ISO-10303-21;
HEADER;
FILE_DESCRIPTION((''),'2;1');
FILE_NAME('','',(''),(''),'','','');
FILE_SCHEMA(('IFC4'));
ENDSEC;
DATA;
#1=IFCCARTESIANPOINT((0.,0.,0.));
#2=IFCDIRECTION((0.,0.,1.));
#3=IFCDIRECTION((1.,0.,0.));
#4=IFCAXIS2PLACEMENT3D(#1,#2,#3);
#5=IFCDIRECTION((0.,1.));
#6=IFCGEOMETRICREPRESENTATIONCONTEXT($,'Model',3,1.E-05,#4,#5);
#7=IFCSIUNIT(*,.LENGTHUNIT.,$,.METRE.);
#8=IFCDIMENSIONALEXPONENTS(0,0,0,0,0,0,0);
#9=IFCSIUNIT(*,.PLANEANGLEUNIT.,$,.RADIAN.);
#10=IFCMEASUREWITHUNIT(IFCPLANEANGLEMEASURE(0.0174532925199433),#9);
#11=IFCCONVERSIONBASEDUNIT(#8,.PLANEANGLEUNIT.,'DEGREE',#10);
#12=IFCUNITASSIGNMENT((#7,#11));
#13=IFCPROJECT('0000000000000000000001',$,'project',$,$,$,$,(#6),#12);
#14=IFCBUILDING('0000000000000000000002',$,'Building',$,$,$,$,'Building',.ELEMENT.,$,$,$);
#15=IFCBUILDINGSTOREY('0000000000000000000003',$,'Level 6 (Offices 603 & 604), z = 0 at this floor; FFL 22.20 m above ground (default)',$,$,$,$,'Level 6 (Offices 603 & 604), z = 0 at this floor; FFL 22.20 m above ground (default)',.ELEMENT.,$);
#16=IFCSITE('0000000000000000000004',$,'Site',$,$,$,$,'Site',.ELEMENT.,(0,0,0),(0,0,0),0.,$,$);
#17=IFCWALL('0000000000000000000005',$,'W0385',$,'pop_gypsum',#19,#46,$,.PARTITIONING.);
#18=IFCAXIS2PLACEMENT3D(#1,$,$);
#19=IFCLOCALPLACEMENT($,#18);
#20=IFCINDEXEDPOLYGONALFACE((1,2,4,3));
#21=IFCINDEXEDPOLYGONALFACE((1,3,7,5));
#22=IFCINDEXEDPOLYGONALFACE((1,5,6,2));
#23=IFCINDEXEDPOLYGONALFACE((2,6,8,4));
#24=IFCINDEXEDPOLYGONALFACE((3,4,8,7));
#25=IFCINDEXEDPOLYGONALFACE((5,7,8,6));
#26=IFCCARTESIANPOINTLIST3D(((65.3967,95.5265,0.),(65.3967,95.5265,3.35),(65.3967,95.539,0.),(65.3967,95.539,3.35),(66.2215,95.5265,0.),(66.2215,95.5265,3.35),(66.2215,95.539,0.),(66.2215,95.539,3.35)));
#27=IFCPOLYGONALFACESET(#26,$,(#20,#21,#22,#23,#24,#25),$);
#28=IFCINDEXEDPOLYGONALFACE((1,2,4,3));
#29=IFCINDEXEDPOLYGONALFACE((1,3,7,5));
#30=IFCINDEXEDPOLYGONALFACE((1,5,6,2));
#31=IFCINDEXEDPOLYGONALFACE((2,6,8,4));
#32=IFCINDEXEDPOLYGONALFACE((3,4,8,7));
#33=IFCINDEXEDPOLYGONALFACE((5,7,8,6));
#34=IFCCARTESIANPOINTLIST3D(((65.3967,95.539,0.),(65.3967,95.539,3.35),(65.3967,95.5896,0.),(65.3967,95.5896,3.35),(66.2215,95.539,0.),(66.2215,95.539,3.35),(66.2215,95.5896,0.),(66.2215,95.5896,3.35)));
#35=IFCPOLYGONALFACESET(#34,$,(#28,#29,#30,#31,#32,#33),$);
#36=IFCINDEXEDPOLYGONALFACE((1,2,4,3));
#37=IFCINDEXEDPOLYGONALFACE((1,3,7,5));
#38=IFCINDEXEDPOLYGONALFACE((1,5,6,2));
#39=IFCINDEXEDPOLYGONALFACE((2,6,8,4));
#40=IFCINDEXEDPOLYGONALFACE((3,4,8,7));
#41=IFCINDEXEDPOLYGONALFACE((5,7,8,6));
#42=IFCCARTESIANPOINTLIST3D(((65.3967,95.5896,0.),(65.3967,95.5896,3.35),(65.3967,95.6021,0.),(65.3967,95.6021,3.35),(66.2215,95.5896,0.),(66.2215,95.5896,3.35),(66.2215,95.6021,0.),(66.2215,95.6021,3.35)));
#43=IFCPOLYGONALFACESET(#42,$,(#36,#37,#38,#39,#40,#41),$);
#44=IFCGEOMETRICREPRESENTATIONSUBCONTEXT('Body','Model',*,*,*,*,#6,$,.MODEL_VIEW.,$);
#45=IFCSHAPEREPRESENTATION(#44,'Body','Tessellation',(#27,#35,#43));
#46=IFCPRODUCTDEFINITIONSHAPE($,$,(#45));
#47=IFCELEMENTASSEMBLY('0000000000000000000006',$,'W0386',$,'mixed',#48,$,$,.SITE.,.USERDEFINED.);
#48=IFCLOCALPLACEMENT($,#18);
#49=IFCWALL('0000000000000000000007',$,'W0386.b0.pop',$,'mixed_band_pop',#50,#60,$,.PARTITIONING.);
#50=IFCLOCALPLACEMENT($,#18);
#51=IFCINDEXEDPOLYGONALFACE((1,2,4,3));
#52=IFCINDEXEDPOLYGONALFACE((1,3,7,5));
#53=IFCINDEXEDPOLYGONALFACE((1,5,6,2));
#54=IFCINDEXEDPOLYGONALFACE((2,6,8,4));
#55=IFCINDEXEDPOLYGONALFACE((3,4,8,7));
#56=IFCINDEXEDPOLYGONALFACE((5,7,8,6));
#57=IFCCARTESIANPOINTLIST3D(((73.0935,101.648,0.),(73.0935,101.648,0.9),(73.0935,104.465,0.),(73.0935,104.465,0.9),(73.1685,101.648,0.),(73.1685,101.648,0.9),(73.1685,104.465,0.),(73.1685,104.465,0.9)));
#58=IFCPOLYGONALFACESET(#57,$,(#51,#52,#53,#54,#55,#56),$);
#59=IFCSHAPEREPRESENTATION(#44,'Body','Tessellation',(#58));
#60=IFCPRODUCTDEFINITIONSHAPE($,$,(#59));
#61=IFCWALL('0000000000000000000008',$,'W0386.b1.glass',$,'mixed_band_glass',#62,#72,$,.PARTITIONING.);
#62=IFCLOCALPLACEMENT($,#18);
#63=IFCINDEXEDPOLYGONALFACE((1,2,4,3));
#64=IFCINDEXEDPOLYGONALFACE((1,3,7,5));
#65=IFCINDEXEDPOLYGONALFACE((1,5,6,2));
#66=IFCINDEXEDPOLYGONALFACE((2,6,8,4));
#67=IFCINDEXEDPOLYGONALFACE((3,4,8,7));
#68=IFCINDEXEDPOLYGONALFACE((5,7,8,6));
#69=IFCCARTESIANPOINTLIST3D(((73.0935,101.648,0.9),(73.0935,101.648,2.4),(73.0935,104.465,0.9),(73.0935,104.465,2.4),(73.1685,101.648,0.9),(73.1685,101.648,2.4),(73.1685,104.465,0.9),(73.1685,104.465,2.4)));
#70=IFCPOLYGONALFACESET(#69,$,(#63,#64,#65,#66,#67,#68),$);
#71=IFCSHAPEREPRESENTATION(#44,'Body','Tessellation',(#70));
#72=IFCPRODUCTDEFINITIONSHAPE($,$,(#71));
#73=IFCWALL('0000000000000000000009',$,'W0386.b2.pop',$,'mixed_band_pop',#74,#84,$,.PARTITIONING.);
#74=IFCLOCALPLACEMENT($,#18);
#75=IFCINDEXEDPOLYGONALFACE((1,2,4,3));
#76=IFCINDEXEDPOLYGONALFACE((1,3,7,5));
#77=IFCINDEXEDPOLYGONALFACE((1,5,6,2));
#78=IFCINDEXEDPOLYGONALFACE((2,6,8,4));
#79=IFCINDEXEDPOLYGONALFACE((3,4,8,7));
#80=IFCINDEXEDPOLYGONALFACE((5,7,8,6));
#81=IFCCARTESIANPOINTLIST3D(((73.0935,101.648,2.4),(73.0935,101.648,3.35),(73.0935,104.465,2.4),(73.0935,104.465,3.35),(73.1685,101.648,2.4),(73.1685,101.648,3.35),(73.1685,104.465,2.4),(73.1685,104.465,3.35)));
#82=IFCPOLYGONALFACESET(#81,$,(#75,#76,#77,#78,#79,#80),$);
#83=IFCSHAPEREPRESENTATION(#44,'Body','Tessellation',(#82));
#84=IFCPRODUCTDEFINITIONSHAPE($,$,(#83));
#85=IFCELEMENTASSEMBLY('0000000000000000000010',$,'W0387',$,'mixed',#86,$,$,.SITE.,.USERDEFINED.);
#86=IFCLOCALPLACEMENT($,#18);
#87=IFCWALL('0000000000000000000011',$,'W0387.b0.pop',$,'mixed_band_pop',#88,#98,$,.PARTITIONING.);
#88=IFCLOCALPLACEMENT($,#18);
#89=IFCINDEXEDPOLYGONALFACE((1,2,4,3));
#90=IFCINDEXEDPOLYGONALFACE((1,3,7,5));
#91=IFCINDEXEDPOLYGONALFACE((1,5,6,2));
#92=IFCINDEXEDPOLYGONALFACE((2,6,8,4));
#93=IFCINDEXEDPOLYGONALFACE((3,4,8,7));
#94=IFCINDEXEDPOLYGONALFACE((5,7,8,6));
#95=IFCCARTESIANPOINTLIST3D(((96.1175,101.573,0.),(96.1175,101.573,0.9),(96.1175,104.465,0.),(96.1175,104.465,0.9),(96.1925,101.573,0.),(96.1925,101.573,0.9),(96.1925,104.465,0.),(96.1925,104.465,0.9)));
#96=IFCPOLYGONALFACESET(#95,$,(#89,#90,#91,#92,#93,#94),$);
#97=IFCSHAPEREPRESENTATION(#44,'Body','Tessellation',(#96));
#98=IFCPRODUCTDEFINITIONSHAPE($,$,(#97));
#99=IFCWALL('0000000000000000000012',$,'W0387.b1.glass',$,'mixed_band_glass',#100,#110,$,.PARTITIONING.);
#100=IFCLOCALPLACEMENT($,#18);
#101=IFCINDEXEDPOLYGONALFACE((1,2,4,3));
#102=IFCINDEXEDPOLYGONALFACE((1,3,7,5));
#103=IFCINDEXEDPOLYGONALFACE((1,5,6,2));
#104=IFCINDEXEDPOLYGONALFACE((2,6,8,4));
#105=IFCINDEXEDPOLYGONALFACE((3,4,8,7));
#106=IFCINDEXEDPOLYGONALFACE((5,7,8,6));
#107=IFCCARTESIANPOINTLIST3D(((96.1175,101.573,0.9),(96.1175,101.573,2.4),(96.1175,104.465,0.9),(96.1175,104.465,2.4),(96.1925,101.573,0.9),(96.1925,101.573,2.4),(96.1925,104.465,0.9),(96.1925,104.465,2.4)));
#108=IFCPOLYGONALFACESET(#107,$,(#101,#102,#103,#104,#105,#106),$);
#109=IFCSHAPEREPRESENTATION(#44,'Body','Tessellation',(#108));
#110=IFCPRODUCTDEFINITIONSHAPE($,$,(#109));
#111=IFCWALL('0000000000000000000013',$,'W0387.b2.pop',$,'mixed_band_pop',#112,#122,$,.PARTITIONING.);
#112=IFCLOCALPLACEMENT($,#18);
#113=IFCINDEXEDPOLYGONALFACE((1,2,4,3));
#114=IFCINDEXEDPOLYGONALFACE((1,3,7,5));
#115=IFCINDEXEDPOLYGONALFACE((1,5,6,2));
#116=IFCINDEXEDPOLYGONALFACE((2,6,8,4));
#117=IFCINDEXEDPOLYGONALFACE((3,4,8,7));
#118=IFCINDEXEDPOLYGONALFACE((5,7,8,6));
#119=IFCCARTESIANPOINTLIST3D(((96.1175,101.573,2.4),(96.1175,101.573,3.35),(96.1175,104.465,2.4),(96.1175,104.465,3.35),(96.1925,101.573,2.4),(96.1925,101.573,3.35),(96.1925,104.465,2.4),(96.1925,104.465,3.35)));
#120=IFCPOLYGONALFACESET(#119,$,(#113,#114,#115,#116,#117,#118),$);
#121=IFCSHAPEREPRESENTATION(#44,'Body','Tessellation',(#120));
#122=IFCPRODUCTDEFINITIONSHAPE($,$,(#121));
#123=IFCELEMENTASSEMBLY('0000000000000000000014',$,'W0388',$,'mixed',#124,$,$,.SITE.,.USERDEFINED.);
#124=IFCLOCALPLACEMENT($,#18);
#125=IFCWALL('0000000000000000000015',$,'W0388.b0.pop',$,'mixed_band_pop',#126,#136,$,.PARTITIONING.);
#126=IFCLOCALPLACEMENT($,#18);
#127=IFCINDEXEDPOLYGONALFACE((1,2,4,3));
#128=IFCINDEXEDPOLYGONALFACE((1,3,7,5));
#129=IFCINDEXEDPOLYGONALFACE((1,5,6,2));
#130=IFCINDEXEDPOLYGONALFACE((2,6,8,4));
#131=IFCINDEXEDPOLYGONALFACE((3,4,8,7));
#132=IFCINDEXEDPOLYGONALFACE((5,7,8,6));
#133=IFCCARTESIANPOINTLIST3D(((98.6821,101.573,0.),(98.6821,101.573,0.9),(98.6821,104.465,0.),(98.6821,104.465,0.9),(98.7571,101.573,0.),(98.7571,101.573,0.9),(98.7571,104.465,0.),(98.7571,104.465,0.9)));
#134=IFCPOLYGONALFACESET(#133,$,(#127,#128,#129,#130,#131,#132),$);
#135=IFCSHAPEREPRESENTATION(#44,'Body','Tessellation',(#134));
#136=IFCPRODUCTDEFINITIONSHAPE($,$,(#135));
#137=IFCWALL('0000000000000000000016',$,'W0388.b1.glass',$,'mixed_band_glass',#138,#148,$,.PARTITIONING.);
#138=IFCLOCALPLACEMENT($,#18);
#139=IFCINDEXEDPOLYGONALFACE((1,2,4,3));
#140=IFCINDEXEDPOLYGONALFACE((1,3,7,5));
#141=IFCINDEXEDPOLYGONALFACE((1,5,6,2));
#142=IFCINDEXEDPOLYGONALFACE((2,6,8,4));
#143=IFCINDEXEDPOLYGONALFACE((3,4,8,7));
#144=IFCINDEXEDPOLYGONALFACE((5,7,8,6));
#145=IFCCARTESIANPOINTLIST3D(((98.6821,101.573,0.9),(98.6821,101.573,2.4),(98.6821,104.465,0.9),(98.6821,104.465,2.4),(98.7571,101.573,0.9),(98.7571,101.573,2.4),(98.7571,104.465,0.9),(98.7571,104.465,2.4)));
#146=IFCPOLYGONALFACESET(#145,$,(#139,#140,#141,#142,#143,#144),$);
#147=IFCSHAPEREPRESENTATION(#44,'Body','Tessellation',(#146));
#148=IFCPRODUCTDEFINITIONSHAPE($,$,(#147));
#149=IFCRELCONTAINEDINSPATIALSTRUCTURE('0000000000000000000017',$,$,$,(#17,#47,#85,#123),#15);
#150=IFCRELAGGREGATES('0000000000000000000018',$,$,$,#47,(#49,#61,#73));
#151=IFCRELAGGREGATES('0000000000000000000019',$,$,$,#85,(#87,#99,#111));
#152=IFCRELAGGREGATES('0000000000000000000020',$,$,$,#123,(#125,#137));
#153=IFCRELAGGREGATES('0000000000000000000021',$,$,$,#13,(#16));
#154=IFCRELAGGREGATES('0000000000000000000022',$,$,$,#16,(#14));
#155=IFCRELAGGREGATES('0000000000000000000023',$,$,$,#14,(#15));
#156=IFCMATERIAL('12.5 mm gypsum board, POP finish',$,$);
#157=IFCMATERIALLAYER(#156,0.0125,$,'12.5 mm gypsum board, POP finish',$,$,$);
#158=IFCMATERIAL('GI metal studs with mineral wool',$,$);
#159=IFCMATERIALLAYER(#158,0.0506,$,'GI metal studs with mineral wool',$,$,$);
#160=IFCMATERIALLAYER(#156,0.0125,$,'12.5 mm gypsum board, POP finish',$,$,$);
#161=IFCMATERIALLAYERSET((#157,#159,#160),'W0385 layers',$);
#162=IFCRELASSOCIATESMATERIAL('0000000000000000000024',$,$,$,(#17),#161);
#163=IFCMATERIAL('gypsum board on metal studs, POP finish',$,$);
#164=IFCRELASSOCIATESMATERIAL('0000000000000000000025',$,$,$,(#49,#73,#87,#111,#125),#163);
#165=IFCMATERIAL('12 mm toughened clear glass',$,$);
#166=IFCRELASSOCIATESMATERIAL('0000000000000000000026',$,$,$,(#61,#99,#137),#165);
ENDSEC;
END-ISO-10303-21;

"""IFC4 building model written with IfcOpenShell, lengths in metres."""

from ifc_helpers import new_model, entity, si_unit, converted_unit, direction, frame, frame_2d, origin_with_axes, place, context, subcontext, project, spatial, rectangle, extrude, material, layer, layer_set, layer_usage, element, aggregate, save


model = new_model("IFC4")

# Units and contexts
model_context = context("Model", 3, precision=1e-05, world=origin_with_axes(), true_north=direction((0.0, 1.0)))
body_context = subcontext(model_context, "Body", "Model", "MODEL_VIEW")
ifc_project = project(units=[si_unit("LENGTHUNIT", "METRE"), converted_unit("PLANEANGLEUNIT", "DEGREE", entity("IfcPlaneAngleMeasure", 0.0174532925199433), si_unit("PLANEANGLEUNIT", "RADIAN"), dimensions=[0, 0, 0, 0, 0, 0, 0])], contexts=[model_context])

# Site, building, storey
site = spatial("IfcSite", under=ifc_project, Name="Site", LongName="Site", CompositionType="ELEMENT", RefLatitude=(0, 0, 0), RefLongitude=(0, 0, 0), RefElevation=0.0)
building = spatial("IfcBuilding", under=site, Name="Building", LongName="Building", CompositionType="ELEMENT")
storey = spatial("IfcBuildingStorey", under=building, Name="Level 6 (Offices 603 & 604), z = 0 at this floor; FFL 22.20 m above ground (default)", LongName="Level 6 (Offices 603 & 604), z = 0 at this floor; FFL 22.20 m above ground (default)", CompositionType="ELEMENT")

# Shared definitions
ifc_material_1 = material(Name="gypsum board on metal studs, POP finish")
placement = place(None, origin_with_axes())

# Shared definitions
ifc_material_2 = material(Name="12 mm toughened clear glass")

# Shared definitions
ifc_material_3 = material(Name="12.5 mm gypsum board, POP finish")
ifc_material_4 = material(Name="GI metal studs with mineral wool")

# Wall
ifc_layer_1 = layer(ifc_material_3, 0.0125, Name="12.5 mm gypsum board, POP finish")
ifc_layer_2 = layer(ifc_material_4, 0.0506, Name="GI metal studs with mineral wool")
ifc_layer_3 = layer(ifc_material_3, 0.0125, Name="12.5 mm gypsum board, POP finish")
ifc_layer_set_1 = layer_set([ifc_layer_1, ifc_layer_2, ifc_layer_3], Name="W0385 layers")
ifc_layer_usage_1 = layer_usage(ifc_layer_set_1, "AXIS2", "POSITIVE", -0.0378)
element("IfcWall", 1, at=placement, inside=storey, material=ifc_layer_usage_1, Name="W0385", ObjectType="pop_gypsum", PredefinedType="PARTITIONING", context=body_context, shape_type="SweptSolid", body=[
    extrude(rectangle(XDim=0.8248, YDim=0.0125, at=frame_2d((0.0, 0.0), x_axis=(1.0, 0.0))), frame((65.8091, 95.5327, 0.0), z_axis=(0.0, 0.0, 1.0), x_axis=(1.0, 0.0, 0.0)), (0.0, 0.0, 1.0), 3.35),
    extrude(rectangle(XDim=0.8248, YDim=0.0506, at=frame_2d((0.0, 0.0315), x_axis=(1.0, 0.0))), frame((65.8091, 95.5327, 0.0), z_axis=(0.0, 0.0, 1.0), x_axis=(1.0, 0.0, 0.0)), (0.0, 0.0, 1.0), 3.35),
    extrude(rectangle(XDim=0.8248, YDim=0.0125, at=frame_2d((0.0, 0.0631), x_axis=(1.0, 0.0))), frame((65.8091, 95.5327, 0.0), z_axis=(0.0, 0.0, 1.0), x_axis=(1.0, 0.0, 0.0)), (0.0, 0.0, 1.0), 3.35),
])

# Element assemblies, walls
assembly_1 = element("IfcElementAssembly", 2, inside=storey, Name="W0386", ObjectType="mixed", AssemblyPlace="SITE", PredefinedType="USERDEFINED")
wall_1 = element("IfcWall", 3, at=placement, material=ifc_material_1, Name="W0386.b0.pop", ObjectType="mixed_band_pop", PredefinedType="PARTITIONING", context=body_context, shape_type="SweptSolid", body=[
    extrude(rectangle(XDim=2.817, YDim=0.075, at=frame_2d((0.0, 0.0), x_axis=(0.0, 1.0))), frame((73.131, 103.0565, 0.0), z_axis=(0.0, 0.0, 1.0), x_axis=(1.0, 0.0, 0.0)), (0.0, 0.0, 1.0), 0.9),
])
wall_2 = element("IfcWall", 4, at=placement, material=ifc_material_2, Name="W0386.b1.glass", ObjectType="mixed_band_glass", PredefinedType="PARTITIONING", context=body_context, shape_type="SweptSolid", body=[
    extrude(rectangle(XDim=2.817, YDim=0.075, at=frame_2d((0.0, 0.0), x_axis=(0.0, 1.0))), frame((73.131, 103.0565, 0.9), z_axis=(0.0, 0.0, 1.0), x_axis=(1.0, 0.0, 0.0)), (0.0, 0.0, 1.0), 1.5),
])
wall_3 = element("IfcWall", 5, at=placement, material=ifc_material_1, Name="W0386.b2.pop", ObjectType="mixed_band_pop", PredefinedType="PARTITIONING", context=body_context, shape_type="SweptSolid", body=[
    extrude(rectangle(XDim=2.817, YDim=0.075, at=frame_2d((0.0, 0.0), x_axis=(0.0, 1.0))), frame((73.131, 103.0565, 2.4), z_axis=(0.0, 0.0, 1.0), x_axis=(1.0, 0.0, 0.0)), (0.0, 0.0, 1.0), 0.95),
])
aggregate(assembly_1, [wall_1, wall_2, wall_3])
assembly_2 = element("IfcElementAssembly", 6, inside=storey, Name="W0387", ObjectType="mixed", AssemblyPlace="SITE", PredefinedType="USERDEFINED")
wall_4 = element("IfcWall", 7, at=placement, material=ifc_material_1, Name="W0387.b0.pop", ObjectType="mixed_band_pop", PredefinedType="PARTITIONING", context=body_context, shape_type="SweptSolid", body=[
    extrude(rectangle(XDim=2.892, YDim=0.075, at=frame_2d((0.0, 0.0), x_axis=(0.0, 1.0))), frame((96.155, 103.019, 0.0), z_axis=(0.0, 0.0, 1.0), x_axis=(1.0, 0.0, 0.0)), (0.0, 0.0, 1.0), 0.9),
])
wall_5 = element("IfcWall", 8, at=placement, material=ifc_material_2, Name="W0387.b1.glass", ObjectType="mixed_band_glass", PredefinedType="PARTITIONING", context=body_context, shape_type="SweptSolid", body=[
    extrude(rectangle(XDim=2.892, YDim=0.075, at=frame_2d((0.0, 0.0), x_axis=(0.0, 1.0))), frame((96.155, 103.019, 0.9), z_axis=(0.0, 0.0, 1.0), x_axis=(1.0, 0.0, 0.0)), (0.0, 0.0, 1.0), 1.5),
])
wall_6 = element("IfcWall", 9, at=placement, material=ifc_material_1, Name="W0387.b2.pop", ObjectType="mixed_band_pop", PredefinedType="PARTITIONING", context=body_context, shape_type="SweptSolid", body=[
    extrude(rectangle(XDim=2.892, YDim=0.075, at=frame_2d((0.0, 0.0), x_axis=(0.0, 1.0))), frame((96.155, 103.019, 2.4), z_axis=(0.0, 0.0, 1.0), x_axis=(1.0, 0.0, 0.0)), (0.0, 0.0, 1.0), 0.95),
])
aggregate(assembly_2, [wall_4, wall_5, wall_6])
assembly_3 = element("IfcElementAssembly", 10, inside=storey, Name="W0388", ObjectType="mixed", AssemblyPlace="SITE", PredefinedType="USERDEFINED")
wall_7 = element("IfcWall", 11, at=placement, material=ifc_material_1, Name="W0388.b0.pop", ObjectType="mixed_band_pop", PredefinedType="PARTITIONING", context=body_context, shape_type="SweptSolid", body=[
    extrude(rectangle(XDim=2.892, YDim=0.075, at=frame_2d((0.0, 0.0), x_axis=(0.0, 1.0))), frame((98.7196, 103.019, 0.0), z_axis=(0.0, 0.0, 1.0), x_axis=(1.0, 0.0, 0.0)), (0.0, 0.0, 1.0), 0.9),
])
wall_8 = element("IfcWall", 12, at=placement, material=ifc_material_2, Name="W0388.b1.glass", ObjectType="mixed_band_glass", PredefinedType="PARTITIONING", context=body_context, shape_type="SweptSolid", body=[
    extrude(rectangle(XDim=2.892, YDim=0.075, at=frame_2d((0.0, 0.0), x_axis=(0.0, 1.0))), frame((98.7196, 103.019, 0.9), z_axis=(0.0, 0.0, 1.0), x_axis=(1.0, 0.0, 0.0)), (0.0, 0.0, 1.0), 1.5),
])
aggregate(assembly_3, [wall_7, wall_8])

save(model, "model.ifc")
